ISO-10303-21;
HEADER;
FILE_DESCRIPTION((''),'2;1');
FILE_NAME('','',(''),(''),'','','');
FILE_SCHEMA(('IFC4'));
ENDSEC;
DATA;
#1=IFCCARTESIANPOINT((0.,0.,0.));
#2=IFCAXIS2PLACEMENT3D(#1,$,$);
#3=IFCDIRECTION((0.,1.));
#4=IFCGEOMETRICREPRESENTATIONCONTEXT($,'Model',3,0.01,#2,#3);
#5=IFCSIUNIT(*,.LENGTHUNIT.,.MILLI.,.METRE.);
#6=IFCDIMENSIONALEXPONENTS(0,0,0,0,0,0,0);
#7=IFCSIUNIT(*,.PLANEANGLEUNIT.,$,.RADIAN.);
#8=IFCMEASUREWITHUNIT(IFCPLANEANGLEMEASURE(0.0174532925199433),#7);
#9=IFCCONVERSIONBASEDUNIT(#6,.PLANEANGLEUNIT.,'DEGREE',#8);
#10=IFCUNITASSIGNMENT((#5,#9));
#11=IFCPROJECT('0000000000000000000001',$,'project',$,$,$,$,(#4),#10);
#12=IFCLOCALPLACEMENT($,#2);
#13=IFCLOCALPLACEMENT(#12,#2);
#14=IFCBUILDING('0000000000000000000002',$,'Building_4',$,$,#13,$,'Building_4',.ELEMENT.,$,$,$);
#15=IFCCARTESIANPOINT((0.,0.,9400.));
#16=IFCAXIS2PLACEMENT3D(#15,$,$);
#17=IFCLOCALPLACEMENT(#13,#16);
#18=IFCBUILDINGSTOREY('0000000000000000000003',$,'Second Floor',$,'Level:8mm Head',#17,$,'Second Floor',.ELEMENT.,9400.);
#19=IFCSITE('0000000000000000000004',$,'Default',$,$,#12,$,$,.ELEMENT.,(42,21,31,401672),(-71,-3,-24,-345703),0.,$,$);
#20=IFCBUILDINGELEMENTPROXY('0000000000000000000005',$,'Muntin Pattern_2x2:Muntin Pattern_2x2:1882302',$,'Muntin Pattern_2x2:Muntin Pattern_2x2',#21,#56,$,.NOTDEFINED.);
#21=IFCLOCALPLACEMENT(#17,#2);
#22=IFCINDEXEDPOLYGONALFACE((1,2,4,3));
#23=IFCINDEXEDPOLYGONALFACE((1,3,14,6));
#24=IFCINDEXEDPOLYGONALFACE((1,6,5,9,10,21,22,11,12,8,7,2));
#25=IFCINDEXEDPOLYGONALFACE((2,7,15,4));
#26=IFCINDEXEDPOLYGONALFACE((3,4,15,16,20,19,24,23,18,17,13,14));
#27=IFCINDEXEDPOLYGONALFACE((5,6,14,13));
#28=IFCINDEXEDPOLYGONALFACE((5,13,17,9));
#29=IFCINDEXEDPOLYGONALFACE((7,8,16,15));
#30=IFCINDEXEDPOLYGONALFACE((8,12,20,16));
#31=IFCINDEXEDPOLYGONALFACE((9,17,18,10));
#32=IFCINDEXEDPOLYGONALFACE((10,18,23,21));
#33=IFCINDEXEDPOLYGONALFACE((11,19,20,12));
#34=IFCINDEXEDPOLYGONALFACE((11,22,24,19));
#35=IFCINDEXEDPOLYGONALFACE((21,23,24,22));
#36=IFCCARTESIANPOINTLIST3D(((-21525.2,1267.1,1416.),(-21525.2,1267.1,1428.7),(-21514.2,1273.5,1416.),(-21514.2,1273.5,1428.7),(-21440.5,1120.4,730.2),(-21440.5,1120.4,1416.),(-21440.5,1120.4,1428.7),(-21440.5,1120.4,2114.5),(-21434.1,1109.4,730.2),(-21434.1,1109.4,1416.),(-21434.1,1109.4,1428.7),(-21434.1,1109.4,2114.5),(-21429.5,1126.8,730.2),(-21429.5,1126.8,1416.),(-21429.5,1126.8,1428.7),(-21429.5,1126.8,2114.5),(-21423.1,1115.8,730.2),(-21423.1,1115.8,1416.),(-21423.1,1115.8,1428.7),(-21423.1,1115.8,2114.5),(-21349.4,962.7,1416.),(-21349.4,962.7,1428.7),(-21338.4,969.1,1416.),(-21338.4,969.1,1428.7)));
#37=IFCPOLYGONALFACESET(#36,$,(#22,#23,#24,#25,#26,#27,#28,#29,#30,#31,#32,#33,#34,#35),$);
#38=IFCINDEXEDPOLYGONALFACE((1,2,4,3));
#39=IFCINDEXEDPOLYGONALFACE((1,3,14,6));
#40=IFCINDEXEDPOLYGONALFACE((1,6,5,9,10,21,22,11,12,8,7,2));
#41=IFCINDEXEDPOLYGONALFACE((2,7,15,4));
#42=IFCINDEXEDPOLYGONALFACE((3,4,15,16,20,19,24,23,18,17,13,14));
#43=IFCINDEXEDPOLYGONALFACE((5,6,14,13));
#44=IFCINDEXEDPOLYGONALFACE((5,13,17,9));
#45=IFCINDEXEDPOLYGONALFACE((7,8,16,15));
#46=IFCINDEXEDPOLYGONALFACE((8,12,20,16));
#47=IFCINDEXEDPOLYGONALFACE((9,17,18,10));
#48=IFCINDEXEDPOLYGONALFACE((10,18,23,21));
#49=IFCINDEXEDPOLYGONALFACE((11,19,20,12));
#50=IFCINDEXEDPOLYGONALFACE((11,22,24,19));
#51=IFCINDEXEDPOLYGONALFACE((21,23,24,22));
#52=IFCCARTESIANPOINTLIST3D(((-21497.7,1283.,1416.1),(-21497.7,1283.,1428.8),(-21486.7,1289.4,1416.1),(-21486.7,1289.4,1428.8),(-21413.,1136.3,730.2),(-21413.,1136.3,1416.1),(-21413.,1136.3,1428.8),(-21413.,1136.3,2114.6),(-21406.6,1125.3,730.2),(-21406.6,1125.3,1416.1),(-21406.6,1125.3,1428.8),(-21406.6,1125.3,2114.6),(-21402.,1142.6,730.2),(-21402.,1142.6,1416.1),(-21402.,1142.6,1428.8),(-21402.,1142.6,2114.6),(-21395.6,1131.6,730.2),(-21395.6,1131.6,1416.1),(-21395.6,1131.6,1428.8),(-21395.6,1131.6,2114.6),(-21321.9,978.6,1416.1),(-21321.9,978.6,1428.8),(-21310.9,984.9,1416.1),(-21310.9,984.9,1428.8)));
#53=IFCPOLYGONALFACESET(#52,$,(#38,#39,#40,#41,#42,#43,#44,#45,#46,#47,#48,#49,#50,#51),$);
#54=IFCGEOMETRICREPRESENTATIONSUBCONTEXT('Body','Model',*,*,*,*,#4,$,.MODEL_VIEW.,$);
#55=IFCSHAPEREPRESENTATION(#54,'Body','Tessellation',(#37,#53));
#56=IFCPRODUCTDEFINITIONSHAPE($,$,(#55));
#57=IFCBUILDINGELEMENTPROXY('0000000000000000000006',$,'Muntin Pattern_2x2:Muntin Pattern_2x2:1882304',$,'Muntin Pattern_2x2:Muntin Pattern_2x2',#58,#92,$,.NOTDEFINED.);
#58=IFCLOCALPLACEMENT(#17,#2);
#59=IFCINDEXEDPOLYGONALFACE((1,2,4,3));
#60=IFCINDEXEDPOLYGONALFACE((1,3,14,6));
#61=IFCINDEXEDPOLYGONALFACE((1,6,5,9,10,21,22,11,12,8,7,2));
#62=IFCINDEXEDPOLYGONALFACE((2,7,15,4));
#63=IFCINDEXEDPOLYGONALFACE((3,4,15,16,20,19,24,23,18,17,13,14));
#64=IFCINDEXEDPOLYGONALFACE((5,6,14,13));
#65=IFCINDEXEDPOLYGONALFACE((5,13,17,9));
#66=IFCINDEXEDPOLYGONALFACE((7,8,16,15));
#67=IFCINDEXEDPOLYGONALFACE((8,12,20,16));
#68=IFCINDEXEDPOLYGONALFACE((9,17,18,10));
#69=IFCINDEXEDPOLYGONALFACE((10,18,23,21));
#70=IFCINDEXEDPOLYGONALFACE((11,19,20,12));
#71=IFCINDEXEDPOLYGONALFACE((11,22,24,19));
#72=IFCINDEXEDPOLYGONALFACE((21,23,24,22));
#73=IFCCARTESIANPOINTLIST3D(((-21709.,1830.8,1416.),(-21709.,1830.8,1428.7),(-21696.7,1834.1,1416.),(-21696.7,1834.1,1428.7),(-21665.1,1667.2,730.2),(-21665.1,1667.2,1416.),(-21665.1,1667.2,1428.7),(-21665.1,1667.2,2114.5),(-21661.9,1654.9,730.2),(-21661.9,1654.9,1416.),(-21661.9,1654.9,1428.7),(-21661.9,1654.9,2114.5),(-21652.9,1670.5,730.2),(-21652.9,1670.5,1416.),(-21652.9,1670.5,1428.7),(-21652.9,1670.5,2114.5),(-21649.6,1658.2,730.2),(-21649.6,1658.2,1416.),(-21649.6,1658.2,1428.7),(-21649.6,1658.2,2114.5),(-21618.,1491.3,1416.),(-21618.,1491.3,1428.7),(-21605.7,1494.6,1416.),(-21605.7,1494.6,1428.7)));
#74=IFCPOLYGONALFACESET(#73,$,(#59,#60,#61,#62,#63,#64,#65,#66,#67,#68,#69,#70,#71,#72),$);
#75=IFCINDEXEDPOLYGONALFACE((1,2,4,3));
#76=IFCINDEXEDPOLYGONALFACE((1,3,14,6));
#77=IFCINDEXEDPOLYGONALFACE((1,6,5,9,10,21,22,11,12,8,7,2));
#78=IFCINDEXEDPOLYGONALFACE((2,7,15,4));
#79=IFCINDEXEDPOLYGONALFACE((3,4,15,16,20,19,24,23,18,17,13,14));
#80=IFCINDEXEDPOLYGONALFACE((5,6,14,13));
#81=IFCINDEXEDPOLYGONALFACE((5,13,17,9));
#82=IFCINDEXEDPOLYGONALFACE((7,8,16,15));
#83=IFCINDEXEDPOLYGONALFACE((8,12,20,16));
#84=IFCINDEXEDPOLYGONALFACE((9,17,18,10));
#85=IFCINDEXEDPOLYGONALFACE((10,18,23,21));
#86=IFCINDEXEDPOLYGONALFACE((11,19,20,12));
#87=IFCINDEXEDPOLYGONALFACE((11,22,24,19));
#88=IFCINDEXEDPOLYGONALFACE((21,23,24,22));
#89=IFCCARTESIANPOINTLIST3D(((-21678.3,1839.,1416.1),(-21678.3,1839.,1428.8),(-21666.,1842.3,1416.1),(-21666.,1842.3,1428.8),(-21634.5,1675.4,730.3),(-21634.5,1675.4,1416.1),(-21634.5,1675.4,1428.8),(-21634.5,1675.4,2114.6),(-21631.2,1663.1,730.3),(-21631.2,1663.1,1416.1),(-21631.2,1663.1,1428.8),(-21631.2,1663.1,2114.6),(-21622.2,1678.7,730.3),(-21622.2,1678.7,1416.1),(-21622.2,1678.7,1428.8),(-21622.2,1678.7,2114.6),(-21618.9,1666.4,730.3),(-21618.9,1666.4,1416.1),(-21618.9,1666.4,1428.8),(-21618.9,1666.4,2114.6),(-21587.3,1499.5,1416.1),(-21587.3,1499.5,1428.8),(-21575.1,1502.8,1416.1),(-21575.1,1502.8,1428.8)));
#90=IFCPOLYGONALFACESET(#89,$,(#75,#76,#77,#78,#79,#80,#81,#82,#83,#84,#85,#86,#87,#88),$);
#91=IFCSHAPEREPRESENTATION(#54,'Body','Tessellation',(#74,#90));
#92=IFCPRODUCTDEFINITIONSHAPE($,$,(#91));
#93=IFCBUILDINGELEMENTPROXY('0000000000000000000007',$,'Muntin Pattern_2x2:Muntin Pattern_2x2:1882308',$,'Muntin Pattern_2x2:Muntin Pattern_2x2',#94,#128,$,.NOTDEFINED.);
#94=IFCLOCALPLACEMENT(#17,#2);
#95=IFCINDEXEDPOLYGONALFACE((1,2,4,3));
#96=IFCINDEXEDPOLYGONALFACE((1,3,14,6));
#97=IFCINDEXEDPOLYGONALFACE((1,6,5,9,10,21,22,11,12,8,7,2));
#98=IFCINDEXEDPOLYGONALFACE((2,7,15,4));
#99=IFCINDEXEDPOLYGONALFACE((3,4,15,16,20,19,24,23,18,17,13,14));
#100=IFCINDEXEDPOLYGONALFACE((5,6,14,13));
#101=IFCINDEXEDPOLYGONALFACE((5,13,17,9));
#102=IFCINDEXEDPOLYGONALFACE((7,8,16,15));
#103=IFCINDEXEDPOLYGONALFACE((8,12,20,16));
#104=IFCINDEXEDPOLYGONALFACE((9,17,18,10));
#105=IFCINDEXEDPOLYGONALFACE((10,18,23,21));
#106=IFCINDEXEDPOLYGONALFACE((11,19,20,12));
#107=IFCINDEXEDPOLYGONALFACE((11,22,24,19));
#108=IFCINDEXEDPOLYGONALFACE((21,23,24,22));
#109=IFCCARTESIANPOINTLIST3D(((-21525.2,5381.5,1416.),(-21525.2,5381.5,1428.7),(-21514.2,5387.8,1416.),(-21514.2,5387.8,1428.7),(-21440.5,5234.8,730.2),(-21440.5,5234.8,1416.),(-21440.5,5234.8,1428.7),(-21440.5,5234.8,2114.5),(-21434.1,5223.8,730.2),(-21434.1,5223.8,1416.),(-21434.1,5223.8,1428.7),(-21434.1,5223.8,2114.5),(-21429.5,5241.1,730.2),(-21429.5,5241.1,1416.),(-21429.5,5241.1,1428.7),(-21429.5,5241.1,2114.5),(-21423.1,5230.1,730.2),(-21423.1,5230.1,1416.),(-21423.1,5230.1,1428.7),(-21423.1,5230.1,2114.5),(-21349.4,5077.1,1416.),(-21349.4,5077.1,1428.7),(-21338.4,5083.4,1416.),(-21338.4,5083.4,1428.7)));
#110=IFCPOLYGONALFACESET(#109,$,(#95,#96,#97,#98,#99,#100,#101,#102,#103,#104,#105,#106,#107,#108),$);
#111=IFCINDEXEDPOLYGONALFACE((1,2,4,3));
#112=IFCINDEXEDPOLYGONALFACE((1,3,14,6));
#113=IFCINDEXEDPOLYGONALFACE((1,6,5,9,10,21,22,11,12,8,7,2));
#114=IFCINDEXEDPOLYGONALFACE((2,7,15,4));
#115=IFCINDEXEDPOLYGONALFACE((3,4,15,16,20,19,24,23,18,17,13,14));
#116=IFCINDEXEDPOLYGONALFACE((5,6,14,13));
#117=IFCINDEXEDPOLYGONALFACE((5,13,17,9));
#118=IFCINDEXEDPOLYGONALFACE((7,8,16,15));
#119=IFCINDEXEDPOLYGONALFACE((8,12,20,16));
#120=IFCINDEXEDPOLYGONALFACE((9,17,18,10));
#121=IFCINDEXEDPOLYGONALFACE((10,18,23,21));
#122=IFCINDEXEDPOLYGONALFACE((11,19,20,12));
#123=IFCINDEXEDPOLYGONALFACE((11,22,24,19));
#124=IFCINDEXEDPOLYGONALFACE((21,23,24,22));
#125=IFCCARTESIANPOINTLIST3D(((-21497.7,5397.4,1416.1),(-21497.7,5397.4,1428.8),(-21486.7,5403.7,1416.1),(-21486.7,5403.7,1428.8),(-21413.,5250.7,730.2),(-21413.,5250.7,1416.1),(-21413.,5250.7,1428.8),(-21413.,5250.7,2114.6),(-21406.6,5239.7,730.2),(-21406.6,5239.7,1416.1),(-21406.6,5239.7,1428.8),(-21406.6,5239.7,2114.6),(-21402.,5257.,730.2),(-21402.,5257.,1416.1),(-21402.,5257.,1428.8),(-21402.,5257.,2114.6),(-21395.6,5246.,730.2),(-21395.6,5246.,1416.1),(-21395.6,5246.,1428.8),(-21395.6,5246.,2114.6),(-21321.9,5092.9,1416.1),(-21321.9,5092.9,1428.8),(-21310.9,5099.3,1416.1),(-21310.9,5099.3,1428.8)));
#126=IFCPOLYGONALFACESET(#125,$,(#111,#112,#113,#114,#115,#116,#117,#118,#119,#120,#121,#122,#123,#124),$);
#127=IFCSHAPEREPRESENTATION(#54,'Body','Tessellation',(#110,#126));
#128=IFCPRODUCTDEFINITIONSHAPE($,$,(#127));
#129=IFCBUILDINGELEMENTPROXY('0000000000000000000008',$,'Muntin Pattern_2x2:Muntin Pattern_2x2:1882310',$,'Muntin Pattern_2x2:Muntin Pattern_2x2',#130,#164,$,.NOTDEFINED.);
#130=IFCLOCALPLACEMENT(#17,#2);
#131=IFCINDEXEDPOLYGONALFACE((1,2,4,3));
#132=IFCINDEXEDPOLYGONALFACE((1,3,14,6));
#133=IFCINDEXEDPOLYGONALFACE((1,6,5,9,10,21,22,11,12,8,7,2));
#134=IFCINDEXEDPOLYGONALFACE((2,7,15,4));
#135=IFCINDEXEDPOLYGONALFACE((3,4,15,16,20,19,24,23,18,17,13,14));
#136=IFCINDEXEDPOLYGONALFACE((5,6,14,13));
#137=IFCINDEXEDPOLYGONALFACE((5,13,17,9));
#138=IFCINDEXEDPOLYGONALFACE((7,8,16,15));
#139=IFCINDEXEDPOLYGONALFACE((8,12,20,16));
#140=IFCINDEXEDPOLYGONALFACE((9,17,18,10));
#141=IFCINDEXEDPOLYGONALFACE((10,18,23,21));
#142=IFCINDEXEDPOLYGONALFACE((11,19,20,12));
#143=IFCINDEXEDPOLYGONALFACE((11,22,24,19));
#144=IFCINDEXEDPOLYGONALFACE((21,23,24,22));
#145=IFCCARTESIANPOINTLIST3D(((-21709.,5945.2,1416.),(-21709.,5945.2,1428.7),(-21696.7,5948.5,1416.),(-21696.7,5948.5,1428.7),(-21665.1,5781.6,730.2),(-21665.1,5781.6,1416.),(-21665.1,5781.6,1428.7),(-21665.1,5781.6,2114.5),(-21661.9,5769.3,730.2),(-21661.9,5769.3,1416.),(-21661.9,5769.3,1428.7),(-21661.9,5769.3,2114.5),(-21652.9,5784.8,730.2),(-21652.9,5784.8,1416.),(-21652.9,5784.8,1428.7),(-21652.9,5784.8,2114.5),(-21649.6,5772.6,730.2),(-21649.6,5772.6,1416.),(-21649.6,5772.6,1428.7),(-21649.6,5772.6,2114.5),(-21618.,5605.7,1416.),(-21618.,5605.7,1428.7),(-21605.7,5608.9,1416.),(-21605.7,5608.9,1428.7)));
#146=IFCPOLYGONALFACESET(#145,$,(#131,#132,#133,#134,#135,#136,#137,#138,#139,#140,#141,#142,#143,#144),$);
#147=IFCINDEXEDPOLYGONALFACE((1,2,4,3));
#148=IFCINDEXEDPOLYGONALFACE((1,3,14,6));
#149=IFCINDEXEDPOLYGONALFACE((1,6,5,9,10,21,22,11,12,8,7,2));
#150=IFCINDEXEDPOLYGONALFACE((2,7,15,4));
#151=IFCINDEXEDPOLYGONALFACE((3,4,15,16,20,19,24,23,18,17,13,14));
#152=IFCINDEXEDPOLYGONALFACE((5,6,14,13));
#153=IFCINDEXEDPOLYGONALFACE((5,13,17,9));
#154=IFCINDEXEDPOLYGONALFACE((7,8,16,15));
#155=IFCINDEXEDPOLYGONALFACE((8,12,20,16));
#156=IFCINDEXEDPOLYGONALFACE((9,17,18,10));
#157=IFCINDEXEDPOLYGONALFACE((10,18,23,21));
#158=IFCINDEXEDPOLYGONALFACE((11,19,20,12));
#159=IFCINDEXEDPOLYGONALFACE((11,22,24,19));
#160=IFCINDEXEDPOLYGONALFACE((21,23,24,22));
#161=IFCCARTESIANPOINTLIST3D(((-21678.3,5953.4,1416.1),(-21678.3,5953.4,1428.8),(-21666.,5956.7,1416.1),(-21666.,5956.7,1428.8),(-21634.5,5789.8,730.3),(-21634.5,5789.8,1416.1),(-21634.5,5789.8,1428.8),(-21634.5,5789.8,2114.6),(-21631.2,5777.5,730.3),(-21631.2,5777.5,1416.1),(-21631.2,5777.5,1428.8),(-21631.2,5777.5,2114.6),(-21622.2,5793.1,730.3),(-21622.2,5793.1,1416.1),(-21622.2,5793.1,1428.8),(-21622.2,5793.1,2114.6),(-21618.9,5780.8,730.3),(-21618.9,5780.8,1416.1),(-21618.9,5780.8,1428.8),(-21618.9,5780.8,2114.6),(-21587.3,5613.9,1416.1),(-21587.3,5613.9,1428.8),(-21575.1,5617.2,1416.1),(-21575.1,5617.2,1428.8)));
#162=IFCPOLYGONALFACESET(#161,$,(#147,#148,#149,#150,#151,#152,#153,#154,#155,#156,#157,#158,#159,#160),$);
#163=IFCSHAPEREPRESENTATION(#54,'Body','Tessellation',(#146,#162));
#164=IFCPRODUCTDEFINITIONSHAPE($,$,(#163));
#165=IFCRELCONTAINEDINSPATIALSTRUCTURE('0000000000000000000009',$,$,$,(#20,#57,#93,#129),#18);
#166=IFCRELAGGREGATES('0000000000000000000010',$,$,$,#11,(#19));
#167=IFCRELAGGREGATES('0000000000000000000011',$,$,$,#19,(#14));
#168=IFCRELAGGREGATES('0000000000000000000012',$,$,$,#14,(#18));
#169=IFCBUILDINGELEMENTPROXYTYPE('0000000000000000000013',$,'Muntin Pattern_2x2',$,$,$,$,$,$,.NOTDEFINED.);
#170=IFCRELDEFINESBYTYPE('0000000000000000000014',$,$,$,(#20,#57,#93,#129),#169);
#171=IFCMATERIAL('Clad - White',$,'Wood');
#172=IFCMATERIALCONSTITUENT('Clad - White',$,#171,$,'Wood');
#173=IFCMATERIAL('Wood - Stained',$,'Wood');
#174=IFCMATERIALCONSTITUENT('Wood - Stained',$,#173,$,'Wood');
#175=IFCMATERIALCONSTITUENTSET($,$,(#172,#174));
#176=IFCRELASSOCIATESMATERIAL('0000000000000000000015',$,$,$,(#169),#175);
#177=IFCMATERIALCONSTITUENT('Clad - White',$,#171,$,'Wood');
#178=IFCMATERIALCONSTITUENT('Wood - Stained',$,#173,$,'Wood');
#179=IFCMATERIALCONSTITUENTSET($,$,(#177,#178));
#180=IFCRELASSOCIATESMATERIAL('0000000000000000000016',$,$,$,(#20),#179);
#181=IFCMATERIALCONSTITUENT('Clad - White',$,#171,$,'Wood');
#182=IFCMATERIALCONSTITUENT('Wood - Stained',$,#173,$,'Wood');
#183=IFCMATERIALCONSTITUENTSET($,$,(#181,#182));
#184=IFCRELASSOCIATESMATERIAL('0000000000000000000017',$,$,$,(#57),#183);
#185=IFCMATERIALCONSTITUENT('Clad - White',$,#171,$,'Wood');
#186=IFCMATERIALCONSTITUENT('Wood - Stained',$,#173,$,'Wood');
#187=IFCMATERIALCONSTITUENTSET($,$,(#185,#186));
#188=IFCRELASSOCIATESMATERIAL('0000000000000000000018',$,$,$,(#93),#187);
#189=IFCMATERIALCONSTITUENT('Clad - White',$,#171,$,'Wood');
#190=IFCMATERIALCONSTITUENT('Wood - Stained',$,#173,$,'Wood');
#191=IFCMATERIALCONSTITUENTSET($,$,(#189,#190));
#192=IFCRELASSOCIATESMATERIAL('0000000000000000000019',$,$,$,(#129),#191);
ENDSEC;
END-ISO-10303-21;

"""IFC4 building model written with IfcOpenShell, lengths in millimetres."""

from ifc_helpers import new_model, entity, si_unit, converted_unit, direction, frame, origin, place, context, subcontext, project, spatial, indexed_curve, outline, extrude, source, transform, mapped, material, constituent, constituent_set, type_object, type_shapes, element, save


model = new_model("IFC4")

# Units and contexts
model_context = context("Model", 3, precision=0.01, world=origin(), true_north=direction((0.0, 1.0)))
body_context = subcontext(model_context, "Body", "Model", "MODEL_VIEW")
ifc_project = project(units=[si_unit("LENGTHUNIT", "METRE", prefix="MILLI"), converted_unit("PLANEANGLEUNIT", "DEGREE", entity("IfcPlaneAngleMeasure", 0.0174532925199433), si_unit("PLANEANGLEUNIT", "RADIAN"), dimensions=[0, 0, 0, 0, 0, 0, 0])], contexts=[model_context])

# Site, building, storey
site_placement = place(None, origin())
site = spatial("IfcSite", under=ifc_project, at=site_placement, Name="Default", CompositionType="ELEMENT", RefLatitude=(42, 21, 31, 401672), RefLongitude=(-71, -3, -24, -345703), RefElevation=0.0)
building_placement = place(site_placement, origin())
building = spatial("IfcBuilding", under=site, at=building_placement, Name="Building_4", LongName="Building_4", CompositionType="ELEMENT")
storey_placement = place(building_placement, frame((0.0, 0.0, 9400.0)))
storey = spatial("IfcBuildingStorey", under=building, at=storey_placement, Name="Second Floor", ObjectType="Level:8mm Head", LongName="Second Floor", CompositionType="ELEMENT", Elevation=9400.0)

# Building element proxies
ifc_material_1 = material(Name="Clad - White", Category="Wood")
ifc_constituent_1 = constituent(ifc_material_1, Name="Clad - White", Category="Wood")
ifc_material_2 = material(Name="Wood - Stained", Category="Wood")
ifc_constituent_2 = constituent(ifc_material_2, Name="Wood - Stained", Category="Wood")
ifc_constituent_set_1 = constituent_set(constituents=[ifc_constituent_1, ifc_constituent_2])
ifc_constituent_3 = constituent(ifc_material_1, Name="Clad - White", Category="Wood")
ifc_constituent_4 = constituent(ifc_material_2, Name="Wood - Stained", Category="Wood")
ifc_constituent_set_2 = constituent_set(constituents=[ifc_constituent_3, ifc_constituent_4])
building_element_proxy_type_1 = type_object("IfcBuildingElementProxyType", Name="Muntin Pattern_2x2", PredefinedType="NOTDEFINED", material=ifc_constituent_set_2)
shared_shape_1 = source(origin(), body_context, "Body", "SweptSolid", [
    extrude(outline(indexed_curve([(6.4, -6.4), (692.1, -6.4), (692.1, 6.3), (6.4, 6.3), (6.4, 175.8), (-6.3, 175.8), (-6.3, 6.3), (-692.2, 6.3), (-692.2, -6.4), (-6.3, -6.4), (-6.3, -175.8), (6.4, -175.8), (6.4, -6.4)], self_intersect=False)), frame((0.0, 9.5, 692.1), z_axis=(0.0, 1.0, 0.0), x_axis=(0.0, 0.0, 1.0)), (0.0, 0.0, 1.0), 12.7),
    extrude(outline(indexed_curve([(6.4, -6.4), (692.1, -6.4), (692.1, 6.3), (6.4, 6.3), (6.4, 175.8), (-6.3, 175.8), (-6.3, 6.3), (-692.2, 6.3), (-692.2, -6.4), (-6.3, -6.4), (-6.3, -175.8), (6.4, -175.8), (6.4, -6.4)], self_intersect=False)), frame((0.0, -22.2, 692.2), z_axis=(0.0, 1.0, 0.0), x_axis=(0.0, 0.0, 1.0)), (0.0, 0.0, 1.0), 12.7),
])
type_shapes(building_element_proxy_type_1, [shared_shape_1])
proxy_1_placement = place(storey_placement, frame((-21418.0, 1126.0, 730.2), z_axis=(0.0, 0.0, 1.0), x_axis=(-0.5, 0.866025, 0.0)))
element("IfcBuildingElementProxy", 1, at=proxy_1_placement, inside=storey, type_object=building_element_proxy_type_1, material=ifc_constituent_set_1, Name="Muntin Pattern_2x2:Muntin Pattern_2x2:1882302", ObjectType="Muntin Pattern_2x2:Muntin Pattern_2x2", PredefinedType="NOTDEFINED", context=body_context, shape_type="MappedRepresentation", body=[
    mapped(shared_shape_1, transform((0.0, 0.0, 0.0), scale=1.0)),
])
ifc_constituent_5 = constituent(ifc_material_1, Name="Clad - White", Category="Wood")
ifc_constituent_6 = constituent(ifc_material_2, Name="Wood - Stained", Category="Wood")
ifc_constituent_set_3 = constituent_set(constituents=[ifc_constituent_5, ifc_constituent_6])
proxy_2_placement = place(storey_placement, frame((-21642.0, 1666.8, 730.3), z_axis=(0.0, 0.0, 1.0), x_axis=(-0.258819, 0.965926, 0.0)))
element("IfcBuildingElementProxy", 2, at=proxy_2_placement, inside=storey, type_object=building_element_proxy_type_1, material=ifc_constituent_set_3, Name="Muntin Pattern_2x2:Muntin Pattern_2x2:1882304", ObjectType="Muntin Pattern_2x2:Muntin Pattern_2x2", PredefinedType="NOTDEFINED", context=body_context, shape_type="MappedRepresentation", body=[
    mapped(shared_shape_1, transform((0.0, 0.0, 0.0), scale=1.0)),
])
ifc_constituent_7 = constituent(ifc_material_1, Name="Clad - White", Category="Wood")
ifc_constituent_8 = constituent(ifc_material_2, Name="Wood - Stained", Category="Wood")
ifc_constituent_set_4 = constituent_set(constituents=[ifc_constituent_7, ifc_constituent_8])
proxy_3_placement = place(storey_placement, frame((-21418.0, 5240.4, 730.2), z_axis=(0.0, 0.0, 1.0), x_axis=(-0.5, 0.866025, 0.0)))
element("IfcBuildingElementProxy", 3, at=proxy_3_placement, inside=storey, type_object=building_element_proxy_type_1, material=ifc_constituent_set_4, Name="Muntin Pattern_2x2:Muntin Pattern_2x2:1882308", ObjectType="Muntin Pattern_2x2:Muntin Pattern_2x2", PredefinedType="NOTDEFINED", context=body_context, shape_type="MappedRepresentation", body=[
    mapped(shared_shape_1, transform((0.0, 0.0, 0.0), scale=1.0)),
])
ifc_constituent_9 = constituent(ifc_material_1, Name="Clad - White", Category="Wood")
ifc_constituent_10 = constituent(ifc_material_2, Name="Wood - Stained", Category="Wood")
ifc_constituent_set_5 = constituent_set(constituents=[ifc_constituent_9, ifc_constituent_10])
proxy_4_placement = place(storey_placement, frame((-21642.0, 5781.2, 730.3), z_axis=(0.0, 0.0, 1.0), x_axis=(-0.258819, 0.965926, 0.0)))
element("IfcBuildingElementProxy", 4, at=proxy_4_placement, inside=storey, type_object=building_element_proxy_type_1, material=ifc_constituent_set_5, Name="Muntin Pattern_2x2:Muntin Pattern_2x2:1882310", ObjectType="Muntin Pattern_2x2:Muntin Pattern_2x2", PredefinedType="NOTDEFINED", context=body_context, shape_type="MappedRepresentation", body=[
    mapped(shared_shape_1, transform((0.0, 0.0, 0.0), scale=1.0)),
])

save(model, "model.ifc")
